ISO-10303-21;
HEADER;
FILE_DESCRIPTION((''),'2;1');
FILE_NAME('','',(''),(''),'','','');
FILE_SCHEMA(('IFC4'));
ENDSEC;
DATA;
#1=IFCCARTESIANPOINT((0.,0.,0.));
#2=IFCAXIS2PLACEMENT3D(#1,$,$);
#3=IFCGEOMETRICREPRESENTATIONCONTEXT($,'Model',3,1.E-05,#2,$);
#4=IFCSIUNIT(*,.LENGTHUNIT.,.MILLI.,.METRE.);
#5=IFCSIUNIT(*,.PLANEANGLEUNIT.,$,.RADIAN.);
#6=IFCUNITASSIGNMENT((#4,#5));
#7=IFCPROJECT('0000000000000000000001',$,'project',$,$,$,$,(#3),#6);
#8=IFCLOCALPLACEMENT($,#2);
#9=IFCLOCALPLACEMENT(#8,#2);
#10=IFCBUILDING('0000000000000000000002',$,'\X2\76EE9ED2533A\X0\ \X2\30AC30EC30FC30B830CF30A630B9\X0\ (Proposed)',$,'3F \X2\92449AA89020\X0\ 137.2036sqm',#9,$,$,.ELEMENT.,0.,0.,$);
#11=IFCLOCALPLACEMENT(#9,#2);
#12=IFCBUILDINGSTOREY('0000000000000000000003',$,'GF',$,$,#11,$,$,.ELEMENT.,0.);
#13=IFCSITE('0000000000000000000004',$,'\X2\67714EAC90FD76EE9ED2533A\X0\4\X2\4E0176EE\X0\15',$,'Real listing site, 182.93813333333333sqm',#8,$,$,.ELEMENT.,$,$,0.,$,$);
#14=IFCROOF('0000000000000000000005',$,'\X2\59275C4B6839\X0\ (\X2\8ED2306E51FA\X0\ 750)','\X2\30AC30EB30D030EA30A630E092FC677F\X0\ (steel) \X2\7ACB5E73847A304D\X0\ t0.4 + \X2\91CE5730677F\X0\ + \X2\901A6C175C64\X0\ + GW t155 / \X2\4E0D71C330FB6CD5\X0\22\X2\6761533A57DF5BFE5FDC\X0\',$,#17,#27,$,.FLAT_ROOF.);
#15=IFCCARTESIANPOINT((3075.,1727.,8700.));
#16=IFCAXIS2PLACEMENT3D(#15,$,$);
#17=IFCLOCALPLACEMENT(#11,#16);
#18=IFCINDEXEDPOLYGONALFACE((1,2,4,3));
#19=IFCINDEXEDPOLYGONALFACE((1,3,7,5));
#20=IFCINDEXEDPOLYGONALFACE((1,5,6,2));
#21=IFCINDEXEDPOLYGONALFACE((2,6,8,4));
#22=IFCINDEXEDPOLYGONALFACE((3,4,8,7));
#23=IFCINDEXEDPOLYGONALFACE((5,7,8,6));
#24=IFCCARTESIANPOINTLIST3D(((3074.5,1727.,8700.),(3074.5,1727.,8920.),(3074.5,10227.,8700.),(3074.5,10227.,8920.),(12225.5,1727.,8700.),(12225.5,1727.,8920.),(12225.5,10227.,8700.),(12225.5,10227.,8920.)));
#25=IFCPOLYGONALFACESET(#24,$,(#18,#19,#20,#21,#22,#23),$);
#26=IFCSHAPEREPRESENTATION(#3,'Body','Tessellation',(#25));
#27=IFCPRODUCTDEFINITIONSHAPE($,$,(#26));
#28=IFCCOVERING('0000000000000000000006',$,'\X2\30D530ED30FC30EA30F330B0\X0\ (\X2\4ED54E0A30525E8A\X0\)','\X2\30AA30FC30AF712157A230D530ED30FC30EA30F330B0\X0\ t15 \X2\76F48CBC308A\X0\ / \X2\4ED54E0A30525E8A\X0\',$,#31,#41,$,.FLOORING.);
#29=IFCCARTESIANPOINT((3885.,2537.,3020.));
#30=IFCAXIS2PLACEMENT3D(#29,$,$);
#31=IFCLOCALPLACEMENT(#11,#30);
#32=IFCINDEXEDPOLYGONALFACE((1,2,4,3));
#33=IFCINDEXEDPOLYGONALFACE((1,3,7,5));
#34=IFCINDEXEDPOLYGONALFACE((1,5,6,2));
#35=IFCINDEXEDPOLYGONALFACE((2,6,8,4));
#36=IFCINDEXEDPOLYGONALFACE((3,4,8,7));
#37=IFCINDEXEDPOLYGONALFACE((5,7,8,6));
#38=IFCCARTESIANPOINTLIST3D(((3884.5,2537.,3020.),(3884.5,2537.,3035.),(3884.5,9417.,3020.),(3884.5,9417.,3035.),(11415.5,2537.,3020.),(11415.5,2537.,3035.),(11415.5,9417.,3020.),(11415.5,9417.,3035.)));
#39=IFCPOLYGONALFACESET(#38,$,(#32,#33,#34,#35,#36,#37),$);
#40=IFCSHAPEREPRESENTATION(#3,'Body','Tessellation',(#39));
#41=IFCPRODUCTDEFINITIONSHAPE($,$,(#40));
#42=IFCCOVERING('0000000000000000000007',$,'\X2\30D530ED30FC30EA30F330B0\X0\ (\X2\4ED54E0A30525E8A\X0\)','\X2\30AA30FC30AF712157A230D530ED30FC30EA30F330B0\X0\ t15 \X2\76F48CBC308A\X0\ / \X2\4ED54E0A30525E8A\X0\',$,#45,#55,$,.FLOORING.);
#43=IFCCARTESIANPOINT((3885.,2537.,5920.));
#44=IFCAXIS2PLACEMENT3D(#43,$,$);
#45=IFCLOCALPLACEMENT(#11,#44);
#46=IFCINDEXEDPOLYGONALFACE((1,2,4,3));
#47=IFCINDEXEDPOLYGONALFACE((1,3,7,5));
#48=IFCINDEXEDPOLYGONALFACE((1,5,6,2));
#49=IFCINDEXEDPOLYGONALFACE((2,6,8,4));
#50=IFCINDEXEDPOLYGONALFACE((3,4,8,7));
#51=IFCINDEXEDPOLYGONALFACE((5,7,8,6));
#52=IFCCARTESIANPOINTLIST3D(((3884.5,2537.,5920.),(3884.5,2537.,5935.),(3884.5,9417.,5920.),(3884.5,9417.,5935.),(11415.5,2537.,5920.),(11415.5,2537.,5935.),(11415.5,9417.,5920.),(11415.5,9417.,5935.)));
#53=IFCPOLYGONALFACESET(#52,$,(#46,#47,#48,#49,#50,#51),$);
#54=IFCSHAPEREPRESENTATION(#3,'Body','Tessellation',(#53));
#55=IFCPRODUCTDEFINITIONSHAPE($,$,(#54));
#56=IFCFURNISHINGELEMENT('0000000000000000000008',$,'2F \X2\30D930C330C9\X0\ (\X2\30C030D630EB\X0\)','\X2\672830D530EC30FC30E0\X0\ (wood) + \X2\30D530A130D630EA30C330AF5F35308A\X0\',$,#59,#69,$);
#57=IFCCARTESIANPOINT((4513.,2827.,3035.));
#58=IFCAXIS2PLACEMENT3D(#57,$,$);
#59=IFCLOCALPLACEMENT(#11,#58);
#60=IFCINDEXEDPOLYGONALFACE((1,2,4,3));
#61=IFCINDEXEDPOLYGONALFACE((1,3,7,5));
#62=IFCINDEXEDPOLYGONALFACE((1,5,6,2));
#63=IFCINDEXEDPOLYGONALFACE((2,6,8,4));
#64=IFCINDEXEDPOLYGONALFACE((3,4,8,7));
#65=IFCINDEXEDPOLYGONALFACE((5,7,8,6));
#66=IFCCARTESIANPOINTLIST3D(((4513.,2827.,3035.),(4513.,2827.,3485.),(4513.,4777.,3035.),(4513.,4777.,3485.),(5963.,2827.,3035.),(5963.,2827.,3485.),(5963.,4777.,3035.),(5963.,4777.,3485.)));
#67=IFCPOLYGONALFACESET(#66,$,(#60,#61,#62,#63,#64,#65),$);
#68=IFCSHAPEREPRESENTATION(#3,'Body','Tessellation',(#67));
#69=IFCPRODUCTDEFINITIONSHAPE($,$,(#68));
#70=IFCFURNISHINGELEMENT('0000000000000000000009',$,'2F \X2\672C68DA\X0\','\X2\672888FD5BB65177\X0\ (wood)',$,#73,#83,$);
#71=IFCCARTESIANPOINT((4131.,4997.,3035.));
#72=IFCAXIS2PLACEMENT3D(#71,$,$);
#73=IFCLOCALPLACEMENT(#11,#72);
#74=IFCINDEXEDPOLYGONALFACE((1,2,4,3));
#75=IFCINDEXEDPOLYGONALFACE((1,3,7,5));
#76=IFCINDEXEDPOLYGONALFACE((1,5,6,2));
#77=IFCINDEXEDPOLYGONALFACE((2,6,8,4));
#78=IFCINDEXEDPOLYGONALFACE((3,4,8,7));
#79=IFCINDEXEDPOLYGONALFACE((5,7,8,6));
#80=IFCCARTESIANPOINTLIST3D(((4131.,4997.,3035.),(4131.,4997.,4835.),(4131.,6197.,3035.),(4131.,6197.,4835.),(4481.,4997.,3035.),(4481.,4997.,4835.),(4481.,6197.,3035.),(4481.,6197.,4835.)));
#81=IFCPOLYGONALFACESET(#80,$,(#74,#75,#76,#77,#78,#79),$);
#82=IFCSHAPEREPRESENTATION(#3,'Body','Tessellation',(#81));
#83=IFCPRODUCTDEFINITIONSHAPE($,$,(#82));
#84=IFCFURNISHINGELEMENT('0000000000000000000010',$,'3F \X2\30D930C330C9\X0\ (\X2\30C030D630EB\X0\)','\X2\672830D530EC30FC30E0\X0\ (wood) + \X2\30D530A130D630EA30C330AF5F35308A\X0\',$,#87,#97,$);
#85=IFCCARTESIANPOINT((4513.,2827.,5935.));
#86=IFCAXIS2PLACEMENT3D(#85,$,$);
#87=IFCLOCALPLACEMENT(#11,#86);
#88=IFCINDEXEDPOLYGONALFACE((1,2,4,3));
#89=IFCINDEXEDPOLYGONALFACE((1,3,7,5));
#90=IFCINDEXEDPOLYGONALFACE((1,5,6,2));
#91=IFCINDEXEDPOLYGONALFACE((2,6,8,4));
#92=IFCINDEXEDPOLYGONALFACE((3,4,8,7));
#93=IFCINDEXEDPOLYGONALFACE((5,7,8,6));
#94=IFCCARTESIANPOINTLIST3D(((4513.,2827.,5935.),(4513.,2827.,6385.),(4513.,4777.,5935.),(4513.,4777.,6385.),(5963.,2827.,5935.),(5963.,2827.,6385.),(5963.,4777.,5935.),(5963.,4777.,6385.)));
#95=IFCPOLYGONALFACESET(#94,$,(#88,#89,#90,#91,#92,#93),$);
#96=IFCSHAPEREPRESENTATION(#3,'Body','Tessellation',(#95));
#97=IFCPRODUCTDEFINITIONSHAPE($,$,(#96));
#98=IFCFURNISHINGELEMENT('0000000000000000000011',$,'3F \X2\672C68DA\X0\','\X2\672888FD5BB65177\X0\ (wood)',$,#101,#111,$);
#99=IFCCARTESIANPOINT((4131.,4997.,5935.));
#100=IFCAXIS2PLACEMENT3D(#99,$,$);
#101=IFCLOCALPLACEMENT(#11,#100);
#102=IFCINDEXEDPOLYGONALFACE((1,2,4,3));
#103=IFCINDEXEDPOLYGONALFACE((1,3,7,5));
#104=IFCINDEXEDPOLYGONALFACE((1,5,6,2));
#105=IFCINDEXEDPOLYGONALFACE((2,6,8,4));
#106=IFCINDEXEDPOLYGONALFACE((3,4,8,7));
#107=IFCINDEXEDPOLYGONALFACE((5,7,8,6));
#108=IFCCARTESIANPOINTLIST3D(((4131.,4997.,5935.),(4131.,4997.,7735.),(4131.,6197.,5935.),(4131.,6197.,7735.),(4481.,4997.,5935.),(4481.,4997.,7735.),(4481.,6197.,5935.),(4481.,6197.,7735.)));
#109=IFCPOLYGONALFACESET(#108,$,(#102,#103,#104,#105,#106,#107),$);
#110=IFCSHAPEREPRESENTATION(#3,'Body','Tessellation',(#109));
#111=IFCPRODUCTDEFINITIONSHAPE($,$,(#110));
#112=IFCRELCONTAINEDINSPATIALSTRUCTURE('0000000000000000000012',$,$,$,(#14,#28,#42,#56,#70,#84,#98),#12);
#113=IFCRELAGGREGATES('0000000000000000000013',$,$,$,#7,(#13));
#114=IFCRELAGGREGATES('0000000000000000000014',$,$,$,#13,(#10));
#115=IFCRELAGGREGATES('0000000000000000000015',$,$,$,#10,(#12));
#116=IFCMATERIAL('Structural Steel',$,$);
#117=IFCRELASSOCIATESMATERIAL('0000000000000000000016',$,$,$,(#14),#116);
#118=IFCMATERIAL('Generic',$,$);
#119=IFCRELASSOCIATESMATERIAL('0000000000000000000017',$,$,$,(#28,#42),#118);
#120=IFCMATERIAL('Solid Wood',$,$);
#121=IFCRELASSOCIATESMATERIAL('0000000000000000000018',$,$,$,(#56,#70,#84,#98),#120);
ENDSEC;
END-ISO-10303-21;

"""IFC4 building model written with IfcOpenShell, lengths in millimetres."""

from ifc_helpers import new_model, si_unit, frame, frame_2d, origin, place, context, project, spatial, rectangle, extrude, material, element, save


model = new_model("IFC4")

# Units and contexts
model_context = context("Model", 3, precision=1e-05, world=origin())
ifc_project = project(units=[si_unit("LENGTHUNIT", "METRE", prefix="MILLI"), si_unit("PLANEANGLEUNIT", "RADIAN")], contexts=[model_context])

# Site, building, storey
site_placement = place(None, origin())
site = spatial("IfcSite", under=ifc_project, at=site_placement, Name="東京都目黒区4丁目15", ObjectType="Real listing site, 182.93813333333333sqm", CompositionType="ELEMENT", RefElevation=0.0)
building_placement = place(site_placement, origin())
building = spatial("IfcBuilding", under=site, at=building_placement, Name="目黒区 ガレージハウス (Proposed)", ObjectType="3F 鉄骨造 137.2036sqm", CompositionType="ELEMENT", ElevationOfRefHeight=0.0, ElevationOfTerrain=0.0)
storey_placement = place(building_placement, origin())
storey = spatial("IfcBuildingStorey", under=building, at=storey_placement, Name="GF", CompositionType="ELEMENT", Elevation=0.0)

# Shared definitions
ifc_material_1 = material(Name="Solid Wood")

# Roof
ifc_material_2 = material(Name="Structural Steel")
roof_placement = place(storey_placement, frame((3075.0, 1727.0, 8700.0)))
element("IfcRoof", 1, at=roof_placement, inside=storey, material=ifc_material_2, Name="大屋根 (軒の出 750)", Description="ガルバリウム鋼板 (steel) 立平葺き t0.4 + 野地板 + 通気層 + GW t155 / 不燃・法22条区域対応", PredefinedType="FLAT_ROOF", context=model_context, shape_type="SweptSolid", body=[
    extrude(rectangle(XDim=9151.0, YDim=8500.0, at=frame_2d((4575.0, 4250.0))), frame((3075.0, 1727.0, 8700.0)), (0.0, 0.0, 1.0), 220.0),
])

# Coverings
ifc_material_3 = material(Name="Generic")
covering_1_placement = place(storey_placement, frame((3885.0, 2537.0, 3020.0)))
element("IfcCovering", 2, at=covering_1_placement, inside=storey, material=ifc_material_3, Name="フローリング (仕上げ床)", Description="オーク無垢フローリング t15 直貼り / 仕上げ床", PredefinedType="FLOORING", context=model_context, shape_type="SweptSolid", body=[
    extrude(rectangle(XDim=7531.0, YDim=6880.0, at=frame_2d((3765.0, 3440.0))), frame((3885.0, 2537.0, 3020.0)), (0.0, 0.0, 1.0), 15.0),
])
covering_2_placement = place(storey_placement, frame((3885.0, 2537.0, 5920.0)))
element("IfcCovering", 3, at=covering_2_placement, inside=storey, material=ifc_material_3, Name="フローリング (仕上げ床)", Description="オーク無垢フローリング t15 直貼り / 仕上げ床", PredefinedType="FLOORING", context=model_context, shape_type="SweptSolid", body=[
    extrude(rectangle(XDim=7531.0, YDim=6880.0, at=frame_2d((3765.0, 3440.0))), frame((3885.0, 2537.0, 5920.0)), (0.0, 0.0, 1.0), 15.0),
])

# Furnishing elements
furnishing_1_placement = place(storey_placement, frame((4513.0, 2827.0, 3035.0)))
element("IfcFurnishingElement", 4, at=furnishing_1_placement, inside=storey, material=ifc_material_1, Name="2F ベッド (ダブル)", Description="木フレーム (wood) + ファブリック張り", context=model_context, shape_type="SweptSolid", body=[
    extrude(rectangle(XDim=1450.0, YDim=1950.0, at=frame_2d((725.0, 975.0))), frame((4513.0, 2827.0, 3035.0)), (0.0, 0.0, 1.0), 450.0),
])
furnishing_2_placement = place(storey_placement, frame((4131.0, 4997.0, 3035.0)))
element("IfcFurnishingElement", 5, at=furnishing_2_placement, inside=storey, material=ifc_material_1, Name="2F 本棚", Description="木製家具 (wood)", context=model_context, shape_type="SweptSolid", body=[
    extrude(rectangle(XDim=350.0, YDim=1200.0, at=frame_2d((175.0, 600.0))), frame((4131.0, 4997.0, 3035.0)), (0.0, 0.0, 1.0), 1800.0),
])
furnishing_3_placement = place(storey_placement, frame((4513.0, 2827.0, 5935.0)))
element("IfcFurnishingElement", 6, at=furnishing_3_placement, inside=storey, material=ifc_material_1, Name="3F ベッド (ダブル)", Description="木フレーム (wood) + ファブリック張り", context=model_context, shape_type="SweptSolid", body=[
    extrude(rectangle(XDim=1450.0, YDim=1950.0, at=frame_2d((725.0, 975.0))), frame((4513.0, 2827.0, 5935.0)), (0.0, 0.0, 1.0), 450.0),
])
furnishing_4_placement = place(storey_placement, frame((4131.0, 4997.0, 5935.0)))
element("IfcFurnishingElement", 7, at=furnishing_4_placement, inside=storey, material=ifc_material_1, Name="3F 本棚", Description="木製家具 (wood)", context=model_context, shape_type="SweptSolid", body=[
    extrude(rectangle(XDim=350.0, YDim=1200.0, at=frame_2d((175.0, 600.0))), frame((4131.0, 4997.0, 5935.0)), (0.0, 0.0, 1.0), 1800.0),
])

save(model, "model.ifc")
